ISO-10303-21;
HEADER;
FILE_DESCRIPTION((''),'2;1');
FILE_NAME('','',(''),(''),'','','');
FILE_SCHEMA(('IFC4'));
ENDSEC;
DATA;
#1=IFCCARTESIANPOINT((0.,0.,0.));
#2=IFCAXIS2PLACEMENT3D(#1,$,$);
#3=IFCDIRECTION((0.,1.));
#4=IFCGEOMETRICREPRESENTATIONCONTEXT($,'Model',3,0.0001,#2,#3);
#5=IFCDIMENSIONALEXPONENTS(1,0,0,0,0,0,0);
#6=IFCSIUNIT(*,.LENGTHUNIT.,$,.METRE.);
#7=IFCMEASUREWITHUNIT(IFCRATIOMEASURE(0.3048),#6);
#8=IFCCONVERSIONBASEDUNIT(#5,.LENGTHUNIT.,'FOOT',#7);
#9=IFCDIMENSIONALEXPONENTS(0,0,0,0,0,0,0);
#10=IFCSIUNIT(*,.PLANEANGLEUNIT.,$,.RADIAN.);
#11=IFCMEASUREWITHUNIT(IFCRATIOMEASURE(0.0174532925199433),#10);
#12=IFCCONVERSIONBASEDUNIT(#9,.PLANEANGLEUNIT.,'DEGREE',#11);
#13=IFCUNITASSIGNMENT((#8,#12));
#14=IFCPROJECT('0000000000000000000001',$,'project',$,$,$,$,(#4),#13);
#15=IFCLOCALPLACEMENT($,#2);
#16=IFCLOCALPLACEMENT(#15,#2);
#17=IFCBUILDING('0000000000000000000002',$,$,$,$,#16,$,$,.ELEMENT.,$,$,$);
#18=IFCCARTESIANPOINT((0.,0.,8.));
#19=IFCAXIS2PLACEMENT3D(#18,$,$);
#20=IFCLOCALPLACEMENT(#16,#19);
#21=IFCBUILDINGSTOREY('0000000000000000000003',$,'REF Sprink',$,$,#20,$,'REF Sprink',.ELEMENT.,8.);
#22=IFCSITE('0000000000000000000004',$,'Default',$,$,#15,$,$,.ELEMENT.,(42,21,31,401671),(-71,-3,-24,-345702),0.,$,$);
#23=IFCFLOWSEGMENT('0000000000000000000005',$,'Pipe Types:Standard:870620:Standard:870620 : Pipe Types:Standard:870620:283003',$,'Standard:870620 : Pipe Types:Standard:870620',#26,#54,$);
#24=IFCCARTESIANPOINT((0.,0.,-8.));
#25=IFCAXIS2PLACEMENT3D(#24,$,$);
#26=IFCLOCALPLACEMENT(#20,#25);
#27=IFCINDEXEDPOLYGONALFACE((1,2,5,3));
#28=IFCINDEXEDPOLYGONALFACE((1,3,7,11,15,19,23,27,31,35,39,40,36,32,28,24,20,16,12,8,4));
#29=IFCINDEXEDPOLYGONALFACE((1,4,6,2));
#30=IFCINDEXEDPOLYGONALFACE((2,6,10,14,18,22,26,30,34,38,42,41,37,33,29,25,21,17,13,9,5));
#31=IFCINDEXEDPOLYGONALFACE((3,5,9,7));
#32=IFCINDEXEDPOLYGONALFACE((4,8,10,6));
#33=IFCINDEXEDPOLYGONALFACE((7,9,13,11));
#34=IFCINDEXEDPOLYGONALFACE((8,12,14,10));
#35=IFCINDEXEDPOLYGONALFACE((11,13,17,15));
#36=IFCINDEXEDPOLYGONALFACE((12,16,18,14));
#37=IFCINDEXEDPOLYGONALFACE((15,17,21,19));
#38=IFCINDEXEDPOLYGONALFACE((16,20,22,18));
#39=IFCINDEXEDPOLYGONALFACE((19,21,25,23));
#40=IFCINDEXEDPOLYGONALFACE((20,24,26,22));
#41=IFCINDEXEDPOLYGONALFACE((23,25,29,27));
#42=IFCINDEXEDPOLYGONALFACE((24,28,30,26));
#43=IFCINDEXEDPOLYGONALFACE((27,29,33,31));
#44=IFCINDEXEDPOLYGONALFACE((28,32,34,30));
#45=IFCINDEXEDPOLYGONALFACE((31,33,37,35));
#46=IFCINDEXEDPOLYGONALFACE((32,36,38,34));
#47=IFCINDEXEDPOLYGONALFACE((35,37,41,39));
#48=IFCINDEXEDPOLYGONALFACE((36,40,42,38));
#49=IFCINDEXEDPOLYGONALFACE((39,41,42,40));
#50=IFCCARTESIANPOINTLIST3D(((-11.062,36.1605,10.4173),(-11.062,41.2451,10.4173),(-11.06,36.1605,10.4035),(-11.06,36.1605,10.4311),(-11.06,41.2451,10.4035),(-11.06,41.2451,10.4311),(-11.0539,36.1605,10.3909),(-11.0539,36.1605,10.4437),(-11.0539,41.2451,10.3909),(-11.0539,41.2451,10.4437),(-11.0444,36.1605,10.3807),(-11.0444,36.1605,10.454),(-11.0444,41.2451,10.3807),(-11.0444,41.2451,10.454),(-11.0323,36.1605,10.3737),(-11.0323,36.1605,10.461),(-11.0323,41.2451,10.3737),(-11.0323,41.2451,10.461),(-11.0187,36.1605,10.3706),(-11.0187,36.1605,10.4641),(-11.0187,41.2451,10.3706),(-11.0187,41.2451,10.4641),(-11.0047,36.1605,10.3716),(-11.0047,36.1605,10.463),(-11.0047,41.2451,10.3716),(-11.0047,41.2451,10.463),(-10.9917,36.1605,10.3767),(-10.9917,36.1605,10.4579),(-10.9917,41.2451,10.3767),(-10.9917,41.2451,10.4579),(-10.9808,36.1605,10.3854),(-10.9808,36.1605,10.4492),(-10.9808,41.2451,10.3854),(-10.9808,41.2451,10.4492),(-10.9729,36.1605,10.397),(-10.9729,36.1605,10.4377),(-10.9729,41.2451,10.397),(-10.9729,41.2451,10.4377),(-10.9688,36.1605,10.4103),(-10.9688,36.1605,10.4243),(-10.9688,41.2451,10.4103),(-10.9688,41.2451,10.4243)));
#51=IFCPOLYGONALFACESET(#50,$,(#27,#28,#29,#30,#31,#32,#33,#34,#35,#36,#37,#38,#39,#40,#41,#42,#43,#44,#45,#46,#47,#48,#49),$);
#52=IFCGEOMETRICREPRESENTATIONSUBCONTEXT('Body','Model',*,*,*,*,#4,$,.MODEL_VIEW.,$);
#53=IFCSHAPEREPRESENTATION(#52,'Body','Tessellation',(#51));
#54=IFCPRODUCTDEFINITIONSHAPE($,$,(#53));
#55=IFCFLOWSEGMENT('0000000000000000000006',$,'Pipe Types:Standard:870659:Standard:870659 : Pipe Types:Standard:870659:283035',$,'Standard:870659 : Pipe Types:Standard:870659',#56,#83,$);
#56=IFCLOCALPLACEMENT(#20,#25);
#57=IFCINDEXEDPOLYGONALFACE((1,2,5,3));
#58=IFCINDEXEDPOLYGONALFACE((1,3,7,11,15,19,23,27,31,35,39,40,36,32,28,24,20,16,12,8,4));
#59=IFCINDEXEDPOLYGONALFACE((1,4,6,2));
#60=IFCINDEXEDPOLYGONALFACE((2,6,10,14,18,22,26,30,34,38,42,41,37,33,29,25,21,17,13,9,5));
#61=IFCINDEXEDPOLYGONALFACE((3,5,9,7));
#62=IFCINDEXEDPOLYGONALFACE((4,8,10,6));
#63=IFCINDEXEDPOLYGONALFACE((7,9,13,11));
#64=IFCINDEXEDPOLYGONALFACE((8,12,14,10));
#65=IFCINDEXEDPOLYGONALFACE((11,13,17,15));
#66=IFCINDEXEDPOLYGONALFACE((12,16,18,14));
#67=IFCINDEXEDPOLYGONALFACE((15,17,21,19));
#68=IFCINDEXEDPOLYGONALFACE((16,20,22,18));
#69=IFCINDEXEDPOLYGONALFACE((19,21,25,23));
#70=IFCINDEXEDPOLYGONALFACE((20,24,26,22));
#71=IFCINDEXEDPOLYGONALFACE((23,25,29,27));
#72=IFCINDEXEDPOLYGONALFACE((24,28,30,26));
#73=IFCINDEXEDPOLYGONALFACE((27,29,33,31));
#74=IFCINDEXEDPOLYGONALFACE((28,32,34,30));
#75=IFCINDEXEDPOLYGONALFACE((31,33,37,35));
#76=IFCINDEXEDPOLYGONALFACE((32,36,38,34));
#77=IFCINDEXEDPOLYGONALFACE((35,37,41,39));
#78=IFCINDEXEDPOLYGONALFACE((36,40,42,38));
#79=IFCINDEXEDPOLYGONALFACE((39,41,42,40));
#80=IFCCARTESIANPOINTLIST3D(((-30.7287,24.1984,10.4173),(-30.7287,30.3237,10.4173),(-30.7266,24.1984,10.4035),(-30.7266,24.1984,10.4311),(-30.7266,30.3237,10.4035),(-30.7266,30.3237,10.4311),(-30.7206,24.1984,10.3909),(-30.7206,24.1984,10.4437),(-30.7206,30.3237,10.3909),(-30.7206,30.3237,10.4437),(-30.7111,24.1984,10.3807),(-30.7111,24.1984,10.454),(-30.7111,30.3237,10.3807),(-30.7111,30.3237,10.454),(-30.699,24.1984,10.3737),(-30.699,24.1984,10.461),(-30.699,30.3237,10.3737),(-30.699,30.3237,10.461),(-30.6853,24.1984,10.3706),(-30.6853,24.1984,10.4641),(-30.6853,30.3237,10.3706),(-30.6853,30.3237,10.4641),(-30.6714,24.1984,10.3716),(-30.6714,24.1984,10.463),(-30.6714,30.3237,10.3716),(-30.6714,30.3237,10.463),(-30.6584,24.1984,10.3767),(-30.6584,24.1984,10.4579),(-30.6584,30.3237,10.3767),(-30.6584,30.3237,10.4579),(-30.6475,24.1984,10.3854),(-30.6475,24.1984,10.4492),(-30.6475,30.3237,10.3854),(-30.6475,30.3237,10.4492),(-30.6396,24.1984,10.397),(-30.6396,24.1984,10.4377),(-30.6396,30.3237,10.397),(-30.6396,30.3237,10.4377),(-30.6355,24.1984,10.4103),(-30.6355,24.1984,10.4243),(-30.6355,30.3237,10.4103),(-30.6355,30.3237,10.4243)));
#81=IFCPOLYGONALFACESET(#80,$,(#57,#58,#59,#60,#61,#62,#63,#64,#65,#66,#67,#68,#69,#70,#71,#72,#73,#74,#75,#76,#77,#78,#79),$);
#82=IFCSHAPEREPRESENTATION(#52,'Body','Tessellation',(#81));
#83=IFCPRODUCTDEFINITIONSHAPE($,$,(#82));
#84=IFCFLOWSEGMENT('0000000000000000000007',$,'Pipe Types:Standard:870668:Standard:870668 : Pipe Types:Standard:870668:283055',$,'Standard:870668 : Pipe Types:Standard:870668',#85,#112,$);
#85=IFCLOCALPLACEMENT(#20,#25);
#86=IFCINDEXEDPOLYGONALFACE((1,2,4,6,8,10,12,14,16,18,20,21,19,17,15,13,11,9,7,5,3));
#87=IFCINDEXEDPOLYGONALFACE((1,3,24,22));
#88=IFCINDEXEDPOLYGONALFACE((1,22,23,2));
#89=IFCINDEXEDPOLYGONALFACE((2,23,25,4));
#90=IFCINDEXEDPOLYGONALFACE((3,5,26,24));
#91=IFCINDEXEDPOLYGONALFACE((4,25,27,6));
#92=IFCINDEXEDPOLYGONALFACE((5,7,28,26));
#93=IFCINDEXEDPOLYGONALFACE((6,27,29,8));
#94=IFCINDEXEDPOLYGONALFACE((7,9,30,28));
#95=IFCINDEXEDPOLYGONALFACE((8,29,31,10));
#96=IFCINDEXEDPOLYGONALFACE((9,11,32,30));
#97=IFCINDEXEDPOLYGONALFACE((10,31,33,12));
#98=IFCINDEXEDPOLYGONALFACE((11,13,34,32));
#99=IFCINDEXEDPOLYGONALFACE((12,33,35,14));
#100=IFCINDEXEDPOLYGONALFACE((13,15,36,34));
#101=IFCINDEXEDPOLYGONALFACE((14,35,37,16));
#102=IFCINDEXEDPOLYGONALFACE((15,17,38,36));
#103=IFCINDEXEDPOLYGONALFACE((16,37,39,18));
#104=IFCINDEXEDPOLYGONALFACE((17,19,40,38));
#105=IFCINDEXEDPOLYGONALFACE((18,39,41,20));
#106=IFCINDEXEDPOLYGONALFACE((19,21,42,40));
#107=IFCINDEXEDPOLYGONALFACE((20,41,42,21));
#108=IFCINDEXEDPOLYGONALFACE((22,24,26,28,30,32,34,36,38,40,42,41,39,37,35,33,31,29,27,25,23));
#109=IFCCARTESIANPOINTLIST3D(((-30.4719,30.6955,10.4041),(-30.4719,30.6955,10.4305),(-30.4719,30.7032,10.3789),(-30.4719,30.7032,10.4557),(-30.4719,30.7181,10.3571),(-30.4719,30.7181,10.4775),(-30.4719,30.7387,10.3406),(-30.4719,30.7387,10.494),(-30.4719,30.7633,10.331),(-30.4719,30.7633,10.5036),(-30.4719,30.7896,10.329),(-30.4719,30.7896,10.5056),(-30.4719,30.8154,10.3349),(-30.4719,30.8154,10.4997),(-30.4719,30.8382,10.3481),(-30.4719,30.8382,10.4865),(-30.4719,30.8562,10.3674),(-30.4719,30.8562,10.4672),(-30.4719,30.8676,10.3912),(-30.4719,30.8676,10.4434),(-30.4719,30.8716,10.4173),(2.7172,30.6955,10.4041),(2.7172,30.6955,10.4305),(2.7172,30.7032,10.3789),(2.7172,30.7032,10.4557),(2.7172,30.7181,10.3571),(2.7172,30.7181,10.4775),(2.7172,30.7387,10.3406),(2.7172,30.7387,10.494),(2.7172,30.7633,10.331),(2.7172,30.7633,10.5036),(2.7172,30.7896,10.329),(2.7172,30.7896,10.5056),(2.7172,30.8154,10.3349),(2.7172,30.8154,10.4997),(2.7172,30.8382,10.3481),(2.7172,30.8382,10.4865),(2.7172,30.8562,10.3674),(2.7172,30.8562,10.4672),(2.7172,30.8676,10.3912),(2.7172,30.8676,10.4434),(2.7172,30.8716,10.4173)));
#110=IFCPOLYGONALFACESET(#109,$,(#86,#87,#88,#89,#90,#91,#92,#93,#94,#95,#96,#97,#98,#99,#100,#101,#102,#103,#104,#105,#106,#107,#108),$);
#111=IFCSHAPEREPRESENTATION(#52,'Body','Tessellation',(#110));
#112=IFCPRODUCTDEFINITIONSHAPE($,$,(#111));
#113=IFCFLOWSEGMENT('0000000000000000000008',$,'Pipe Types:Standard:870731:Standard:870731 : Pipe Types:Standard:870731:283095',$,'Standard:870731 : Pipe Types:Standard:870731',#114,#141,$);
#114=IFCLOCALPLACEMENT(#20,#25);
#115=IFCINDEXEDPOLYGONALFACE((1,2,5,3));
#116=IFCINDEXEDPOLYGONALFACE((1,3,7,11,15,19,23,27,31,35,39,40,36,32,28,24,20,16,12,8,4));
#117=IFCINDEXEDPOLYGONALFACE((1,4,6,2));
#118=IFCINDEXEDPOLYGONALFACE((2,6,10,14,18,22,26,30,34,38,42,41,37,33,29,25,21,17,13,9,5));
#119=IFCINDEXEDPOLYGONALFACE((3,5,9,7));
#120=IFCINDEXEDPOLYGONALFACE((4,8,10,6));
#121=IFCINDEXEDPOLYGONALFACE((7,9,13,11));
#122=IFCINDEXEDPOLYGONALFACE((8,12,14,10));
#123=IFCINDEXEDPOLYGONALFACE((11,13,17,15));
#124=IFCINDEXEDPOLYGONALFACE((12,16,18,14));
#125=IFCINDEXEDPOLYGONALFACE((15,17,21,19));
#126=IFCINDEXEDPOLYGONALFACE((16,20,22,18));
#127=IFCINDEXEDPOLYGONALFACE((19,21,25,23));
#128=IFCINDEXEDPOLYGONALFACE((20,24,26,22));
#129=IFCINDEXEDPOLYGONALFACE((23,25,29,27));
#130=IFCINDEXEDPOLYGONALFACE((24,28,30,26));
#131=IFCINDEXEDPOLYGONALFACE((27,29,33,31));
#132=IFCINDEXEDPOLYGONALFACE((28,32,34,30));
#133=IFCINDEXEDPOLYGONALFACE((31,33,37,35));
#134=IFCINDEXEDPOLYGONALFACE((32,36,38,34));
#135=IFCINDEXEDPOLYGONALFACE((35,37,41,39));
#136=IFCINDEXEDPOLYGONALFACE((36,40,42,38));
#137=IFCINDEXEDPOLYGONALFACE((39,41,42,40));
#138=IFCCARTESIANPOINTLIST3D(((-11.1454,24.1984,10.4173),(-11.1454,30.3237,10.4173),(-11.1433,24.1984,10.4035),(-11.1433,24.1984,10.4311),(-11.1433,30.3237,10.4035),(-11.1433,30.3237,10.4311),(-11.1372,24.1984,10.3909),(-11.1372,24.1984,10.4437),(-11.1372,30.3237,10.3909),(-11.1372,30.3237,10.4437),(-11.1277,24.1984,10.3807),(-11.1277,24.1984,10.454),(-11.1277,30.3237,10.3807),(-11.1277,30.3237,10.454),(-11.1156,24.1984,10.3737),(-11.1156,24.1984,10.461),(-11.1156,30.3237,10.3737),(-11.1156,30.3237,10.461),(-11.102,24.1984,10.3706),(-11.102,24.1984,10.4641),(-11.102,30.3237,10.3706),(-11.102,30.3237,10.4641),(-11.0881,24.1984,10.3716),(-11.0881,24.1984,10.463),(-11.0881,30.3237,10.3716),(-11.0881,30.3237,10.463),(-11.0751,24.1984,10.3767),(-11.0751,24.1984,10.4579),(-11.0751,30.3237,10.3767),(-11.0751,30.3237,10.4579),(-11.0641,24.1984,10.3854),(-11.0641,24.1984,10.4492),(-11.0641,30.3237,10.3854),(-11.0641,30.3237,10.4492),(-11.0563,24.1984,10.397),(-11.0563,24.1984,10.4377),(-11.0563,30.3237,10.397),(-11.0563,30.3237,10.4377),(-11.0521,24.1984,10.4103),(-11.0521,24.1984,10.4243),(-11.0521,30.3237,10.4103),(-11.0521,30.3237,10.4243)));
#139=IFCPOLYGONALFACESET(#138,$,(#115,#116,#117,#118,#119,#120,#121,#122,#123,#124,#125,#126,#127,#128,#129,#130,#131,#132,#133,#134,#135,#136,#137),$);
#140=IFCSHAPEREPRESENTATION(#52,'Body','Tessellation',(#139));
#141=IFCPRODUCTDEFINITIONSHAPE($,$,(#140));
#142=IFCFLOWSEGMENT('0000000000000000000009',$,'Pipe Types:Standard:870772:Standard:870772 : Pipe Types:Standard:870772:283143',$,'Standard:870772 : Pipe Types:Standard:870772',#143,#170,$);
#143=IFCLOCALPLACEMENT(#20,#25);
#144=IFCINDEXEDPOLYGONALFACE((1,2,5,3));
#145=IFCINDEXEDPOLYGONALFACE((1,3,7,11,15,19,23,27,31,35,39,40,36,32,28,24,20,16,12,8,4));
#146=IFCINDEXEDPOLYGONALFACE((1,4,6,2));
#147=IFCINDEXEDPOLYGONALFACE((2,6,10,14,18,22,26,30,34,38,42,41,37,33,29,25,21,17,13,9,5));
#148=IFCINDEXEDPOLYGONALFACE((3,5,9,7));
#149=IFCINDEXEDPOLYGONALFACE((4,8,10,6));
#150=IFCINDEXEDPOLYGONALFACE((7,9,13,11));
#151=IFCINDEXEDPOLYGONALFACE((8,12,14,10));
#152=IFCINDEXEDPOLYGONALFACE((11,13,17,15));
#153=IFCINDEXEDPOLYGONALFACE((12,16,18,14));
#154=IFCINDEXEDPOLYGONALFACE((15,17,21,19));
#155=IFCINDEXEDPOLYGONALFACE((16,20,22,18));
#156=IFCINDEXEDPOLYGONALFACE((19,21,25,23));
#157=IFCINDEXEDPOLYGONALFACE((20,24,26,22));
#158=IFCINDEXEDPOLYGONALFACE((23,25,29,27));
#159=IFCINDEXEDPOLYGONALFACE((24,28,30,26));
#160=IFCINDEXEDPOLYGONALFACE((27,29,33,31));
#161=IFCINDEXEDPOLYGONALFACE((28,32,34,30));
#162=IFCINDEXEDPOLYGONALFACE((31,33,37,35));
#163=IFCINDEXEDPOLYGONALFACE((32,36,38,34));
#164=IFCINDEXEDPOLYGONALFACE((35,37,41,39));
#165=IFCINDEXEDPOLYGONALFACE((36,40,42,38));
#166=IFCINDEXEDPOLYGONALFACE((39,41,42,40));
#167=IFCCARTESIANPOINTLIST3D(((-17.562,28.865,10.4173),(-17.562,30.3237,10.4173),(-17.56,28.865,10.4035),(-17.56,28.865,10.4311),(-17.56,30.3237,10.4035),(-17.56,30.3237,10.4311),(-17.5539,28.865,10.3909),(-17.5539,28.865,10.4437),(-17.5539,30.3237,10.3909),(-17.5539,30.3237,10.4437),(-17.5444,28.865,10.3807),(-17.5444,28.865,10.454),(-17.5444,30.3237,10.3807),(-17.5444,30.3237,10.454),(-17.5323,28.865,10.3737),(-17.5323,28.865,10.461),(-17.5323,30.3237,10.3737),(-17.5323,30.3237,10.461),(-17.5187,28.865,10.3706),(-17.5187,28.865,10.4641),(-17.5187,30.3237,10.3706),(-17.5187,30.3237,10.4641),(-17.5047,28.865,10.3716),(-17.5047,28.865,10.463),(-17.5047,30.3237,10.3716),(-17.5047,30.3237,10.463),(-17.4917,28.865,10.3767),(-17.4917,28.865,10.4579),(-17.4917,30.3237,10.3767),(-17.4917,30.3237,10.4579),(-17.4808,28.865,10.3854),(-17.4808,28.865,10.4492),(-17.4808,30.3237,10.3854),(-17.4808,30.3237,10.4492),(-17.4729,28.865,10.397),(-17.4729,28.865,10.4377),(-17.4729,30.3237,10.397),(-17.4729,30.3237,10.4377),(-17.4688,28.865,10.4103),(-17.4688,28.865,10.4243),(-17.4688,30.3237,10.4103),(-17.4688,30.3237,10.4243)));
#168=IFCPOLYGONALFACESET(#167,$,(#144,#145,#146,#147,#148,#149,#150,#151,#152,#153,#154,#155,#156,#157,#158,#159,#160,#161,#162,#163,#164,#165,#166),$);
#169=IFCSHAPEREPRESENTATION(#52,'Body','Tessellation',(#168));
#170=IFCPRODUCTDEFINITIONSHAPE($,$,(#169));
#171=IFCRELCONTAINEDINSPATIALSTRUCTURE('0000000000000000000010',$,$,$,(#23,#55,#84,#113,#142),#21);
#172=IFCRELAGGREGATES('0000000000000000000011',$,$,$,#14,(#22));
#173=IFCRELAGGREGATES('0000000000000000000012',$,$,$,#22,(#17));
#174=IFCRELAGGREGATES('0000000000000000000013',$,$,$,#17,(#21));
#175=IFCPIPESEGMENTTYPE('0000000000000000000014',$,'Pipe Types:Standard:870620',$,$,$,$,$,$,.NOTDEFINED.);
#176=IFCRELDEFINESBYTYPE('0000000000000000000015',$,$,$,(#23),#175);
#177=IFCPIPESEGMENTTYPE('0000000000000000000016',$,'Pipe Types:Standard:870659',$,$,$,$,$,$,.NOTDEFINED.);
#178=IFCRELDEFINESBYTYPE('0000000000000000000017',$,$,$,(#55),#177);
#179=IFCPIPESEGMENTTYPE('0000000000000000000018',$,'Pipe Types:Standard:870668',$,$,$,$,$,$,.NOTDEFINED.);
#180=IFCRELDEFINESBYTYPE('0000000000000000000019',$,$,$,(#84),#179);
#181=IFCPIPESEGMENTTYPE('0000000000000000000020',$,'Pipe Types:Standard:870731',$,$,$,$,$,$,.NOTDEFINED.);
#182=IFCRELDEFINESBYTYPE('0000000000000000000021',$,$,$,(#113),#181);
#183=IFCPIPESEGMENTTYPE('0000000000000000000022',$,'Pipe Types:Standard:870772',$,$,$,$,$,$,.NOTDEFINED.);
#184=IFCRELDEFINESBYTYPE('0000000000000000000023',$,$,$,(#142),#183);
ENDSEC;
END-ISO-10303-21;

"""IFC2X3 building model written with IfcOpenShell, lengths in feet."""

from ifc_helpers import new_model, entity, si_unit, converted_unit, direction, frame, origin, origin_2d_with_axis, place, context, subcontext, project, spatial, circle, extrude, source, transform, mapped, type_object, type_shapes, element, save


model = new_model("IFC2X3")

# Units and contexts
model_context = context("Model", 3, precision=0.0001, world=origin(), true_north=direction((0.0, 1.0)))
body_context = subcontext(model_context, "Body", "Model", "MODEL_VIEW")
ifc_project = project(units=[converted_unit("LENGTHUNIT", "FOOT", entity("IfcRatioMeasure", 0.3048), si_unit("LENGTHUNIT", "METRE"), dimensions=[1, 0, 0, 0, 0, 0, 0]), converted_unit("PLANEANGLEUNIT", "DEGREE", entity("IfcRatioMeasure", 0.0174532925199433), si_unit("PLANEANGLEUNIT", "RADIAN"), dimensions=[0, 0, 0, 0, 0, 0, 0])], contexts=[model_context])

# Site, building, storey
site_placement = place(None, origin())
site = spatial("IfcSite", under=ifc_project, at=site_placement, Name="Default", CompositionType="ELEMENT", RefLatitude=(42, 21, 31, 401671), RefLongitude=(-71, -3, -24, -345702), RefElevation=0.0)
building_placement = place(site_placement, origin())
building = spatial("IfcBuilding", under=site, at=building_placement, CompositionType="ELEMENT")
storey_placement = place(building_placement, frame((0.0, 0.0, 8.0)))
storey = spatial("IfcBuildingStorey", under=building, at=storey_placement, Name="REF Sprink", LongName="REF Sprink", CompositionType="ELEMENT", Elevation=8.0)

# Flow segments
pipe_segment_type_1 = type_object("IfcPipeSegmentType", Name="Pipe Types:Standard:870620", PredefinedType="NOTDEFINED")
shared_shape_1 = source(origin(), body_context, "Body", "SweptSolid", [
    extrude(circle(Radius=0.0469, at=origin_2d_with_axis()), frame((-11.0152, 36.1605, 10.4173), z_axis=(0.0, 1.0, 0.0), x_axis=(-1.0, 0.0, 0.0)), (0.0, 0.0, 1.0), 5.0846),
])
type_shapes(pipe_segment_type_1, [shared_shape_1])
flow_segment_1_placement = place(storey_placement, frame((0.0, 0.0, -8.0)))
element("IfcFlowSegment", 1, at=flow_segment_1_placement, inside=storey, type_object=pipe_segment_type_1, Name="Pipe Types:Standard:870620:Standard:870620 : Pipe Types:Standard:870620:283003", ObjectType="Standard:870620 : Pipe Types:Standard:870620", context=body_context, shape_type="MappedRepresentation", body=[
    mapped(shared_shape_1, transform((0.0, 0.0, 0.0), scale=1.0)),
])
pipe_segment_type_2 = type_object("IfcPipeSegmentType", Name="Pipe Types:Standard:870659", PredefinedType="NOTDEFINED")
shared_shape_2 = source(origin(), body_context, "Body", "SweptSolid", [
    extrude(circle(Radius=0.0469, at=origin_2d_with_axis()), frame((-30.6818, 24.1984, 10.4173), z_axis=(0.0, 1.0, 0.0), x_axis=(-1.0, 0.0, 0.0)), (0.0, 0.0, 1.0), 6.1253),
])
type_shapes(pipe_segment_type_2, [shared_shape_2])
flow_segment_2_placement = place(storey_placement, frame((0.0, 0.0, -8.0)))
element("IfcFlowSegment", 2, at=flow_segment_2_placement, inside=storey, type_object=pipe_segment_type_2, Name="Pipe Types:Standard:870659:Standard:870659 : Pipe Types:Standard:870659:283035", ObjectType="Standard:870659 : Pipe Types:Standard:870659", context=body_context, shape_type="MappedRepresentation", body=[
    mapped(shared_shape_2, transform((0.0, 0.0, 0.0), scale=1.0)),
])
pipe_segment_type_3 = type_object("IfcPipeSegmentType", Name="Pipe Types:Standard:870668", PredefinedType="NOTDEFINED")
shared_shape_3 = source(origin(), body_context, "Body", "SweptSolid", [
    extrude(circle(Radius=0.0885, at=origin_2d_with_axis()), frame((-30.4719, 30.783, 10.4173), z_axis=(1.0, 0.0, 0.0), x_axis=(0.0, 1.0, 0.0)), (0.0, 0.0, 1.0), 33.1891),
])
type_shapes(pipe_segment_type_3, [shared_shape_3])
flow_segment_3_placement = place(storey_placement, frame((0.0, 0.0, -8.0)))
element("IfcFlowSegment", 3, at=flow_segment_3_placement, inside=storey, type_object=pipe_segment_type_3, Name="Pipe Types:Standard:870668:Standard:870668 : Pipe Types:Standard:870668:283055", ObjectType="Standard:870668 : Pipe Types:Standard:870668", context=body_context, shape_type="MappedRepresentation", body=[
    mapped(shared_shape_3, transform((0.0, 0.0, 0.0), scale=1.0)),
])
pipe_segment_type_4 = type_object("IfcPipeSegmentType", Name="Pipe Types:Standard:870731", PredefinedType="NOTDEFINED")
shared_shape_4 = source(origin(), body_context, "Body", "SweptSolid", [
    extrude(circle(Radius=0.0469, at=origin_2d_with_axis()), frame((-11.0985, 24.1984, 10.4173), z_axis=(0.0, 1.0, 0.0), x_axis=(-1.0, 0.0, 0.0)), (0.0, 0.0, 1.0), 6.1253),
])
type_shapes(pipe_segment_type_4, [shared_shape_4])
flow_segment_4_placement = place(storey_placement, frame((0.0, 0.0, -8.0)))
element("IfcFlowSegment", 4, at=flow_segment_4_placement, inside=storey, type_object=pipe_segment_type_4, Name="Pipe Types:Standard:870731:Standard:870731 : Pipe Types:Standard:870731:283095", ObjectType="Standard:870731 : Pipe Types:Standard:870731", context=body_context, shape_type="MappedRepresentation", body=[
    mapped(shared_shape_4, transform((0.0, 0.0, 0.0), scale=1.0)),
])
pipe_segment_type_5 = type_object("IfcPipeSegmentType", Name="Pipe Types:Standard:870772", PredefinedType="NOTDEFINED")
shared_shape_5 = source(origin(), body_context, "Body", "SweptSolid", [
    extrude(circle(Radius=0.0469, at=origin_2d_with_axis()), frame((-17.5152, 28.865, 10.4173), z_axis=(0.0, 1.0, 0.0), x_axis=(-1.0, 0.0, 0.0)), (0.0, 0.0, 1.0), 1.4587),
])
type_shapes(pipe_segment_type_5, [shared_shape_5])
flow_segment_5_placement = place(storey_placement, frame((0.0, 0.0, -8.0)))
element("IfcFlowSegment", 5, at=flow_segment_5_placement, inside=storey, type_object=pipe_segment_type_5, Name="Pipe Types:Standard:870772:Standard:870772 : Pipe Types:Standard:870772:283143", ObjectType="Standard:870772 : Pipe Types:Standard:870772", context=body_context, shape_type="MappedRepresentation", body=[
    mapped(shared_shape_5, transform((0.0, 0.0, 0.0), scale=1.0)),
])

save(model, "model.ifc")
